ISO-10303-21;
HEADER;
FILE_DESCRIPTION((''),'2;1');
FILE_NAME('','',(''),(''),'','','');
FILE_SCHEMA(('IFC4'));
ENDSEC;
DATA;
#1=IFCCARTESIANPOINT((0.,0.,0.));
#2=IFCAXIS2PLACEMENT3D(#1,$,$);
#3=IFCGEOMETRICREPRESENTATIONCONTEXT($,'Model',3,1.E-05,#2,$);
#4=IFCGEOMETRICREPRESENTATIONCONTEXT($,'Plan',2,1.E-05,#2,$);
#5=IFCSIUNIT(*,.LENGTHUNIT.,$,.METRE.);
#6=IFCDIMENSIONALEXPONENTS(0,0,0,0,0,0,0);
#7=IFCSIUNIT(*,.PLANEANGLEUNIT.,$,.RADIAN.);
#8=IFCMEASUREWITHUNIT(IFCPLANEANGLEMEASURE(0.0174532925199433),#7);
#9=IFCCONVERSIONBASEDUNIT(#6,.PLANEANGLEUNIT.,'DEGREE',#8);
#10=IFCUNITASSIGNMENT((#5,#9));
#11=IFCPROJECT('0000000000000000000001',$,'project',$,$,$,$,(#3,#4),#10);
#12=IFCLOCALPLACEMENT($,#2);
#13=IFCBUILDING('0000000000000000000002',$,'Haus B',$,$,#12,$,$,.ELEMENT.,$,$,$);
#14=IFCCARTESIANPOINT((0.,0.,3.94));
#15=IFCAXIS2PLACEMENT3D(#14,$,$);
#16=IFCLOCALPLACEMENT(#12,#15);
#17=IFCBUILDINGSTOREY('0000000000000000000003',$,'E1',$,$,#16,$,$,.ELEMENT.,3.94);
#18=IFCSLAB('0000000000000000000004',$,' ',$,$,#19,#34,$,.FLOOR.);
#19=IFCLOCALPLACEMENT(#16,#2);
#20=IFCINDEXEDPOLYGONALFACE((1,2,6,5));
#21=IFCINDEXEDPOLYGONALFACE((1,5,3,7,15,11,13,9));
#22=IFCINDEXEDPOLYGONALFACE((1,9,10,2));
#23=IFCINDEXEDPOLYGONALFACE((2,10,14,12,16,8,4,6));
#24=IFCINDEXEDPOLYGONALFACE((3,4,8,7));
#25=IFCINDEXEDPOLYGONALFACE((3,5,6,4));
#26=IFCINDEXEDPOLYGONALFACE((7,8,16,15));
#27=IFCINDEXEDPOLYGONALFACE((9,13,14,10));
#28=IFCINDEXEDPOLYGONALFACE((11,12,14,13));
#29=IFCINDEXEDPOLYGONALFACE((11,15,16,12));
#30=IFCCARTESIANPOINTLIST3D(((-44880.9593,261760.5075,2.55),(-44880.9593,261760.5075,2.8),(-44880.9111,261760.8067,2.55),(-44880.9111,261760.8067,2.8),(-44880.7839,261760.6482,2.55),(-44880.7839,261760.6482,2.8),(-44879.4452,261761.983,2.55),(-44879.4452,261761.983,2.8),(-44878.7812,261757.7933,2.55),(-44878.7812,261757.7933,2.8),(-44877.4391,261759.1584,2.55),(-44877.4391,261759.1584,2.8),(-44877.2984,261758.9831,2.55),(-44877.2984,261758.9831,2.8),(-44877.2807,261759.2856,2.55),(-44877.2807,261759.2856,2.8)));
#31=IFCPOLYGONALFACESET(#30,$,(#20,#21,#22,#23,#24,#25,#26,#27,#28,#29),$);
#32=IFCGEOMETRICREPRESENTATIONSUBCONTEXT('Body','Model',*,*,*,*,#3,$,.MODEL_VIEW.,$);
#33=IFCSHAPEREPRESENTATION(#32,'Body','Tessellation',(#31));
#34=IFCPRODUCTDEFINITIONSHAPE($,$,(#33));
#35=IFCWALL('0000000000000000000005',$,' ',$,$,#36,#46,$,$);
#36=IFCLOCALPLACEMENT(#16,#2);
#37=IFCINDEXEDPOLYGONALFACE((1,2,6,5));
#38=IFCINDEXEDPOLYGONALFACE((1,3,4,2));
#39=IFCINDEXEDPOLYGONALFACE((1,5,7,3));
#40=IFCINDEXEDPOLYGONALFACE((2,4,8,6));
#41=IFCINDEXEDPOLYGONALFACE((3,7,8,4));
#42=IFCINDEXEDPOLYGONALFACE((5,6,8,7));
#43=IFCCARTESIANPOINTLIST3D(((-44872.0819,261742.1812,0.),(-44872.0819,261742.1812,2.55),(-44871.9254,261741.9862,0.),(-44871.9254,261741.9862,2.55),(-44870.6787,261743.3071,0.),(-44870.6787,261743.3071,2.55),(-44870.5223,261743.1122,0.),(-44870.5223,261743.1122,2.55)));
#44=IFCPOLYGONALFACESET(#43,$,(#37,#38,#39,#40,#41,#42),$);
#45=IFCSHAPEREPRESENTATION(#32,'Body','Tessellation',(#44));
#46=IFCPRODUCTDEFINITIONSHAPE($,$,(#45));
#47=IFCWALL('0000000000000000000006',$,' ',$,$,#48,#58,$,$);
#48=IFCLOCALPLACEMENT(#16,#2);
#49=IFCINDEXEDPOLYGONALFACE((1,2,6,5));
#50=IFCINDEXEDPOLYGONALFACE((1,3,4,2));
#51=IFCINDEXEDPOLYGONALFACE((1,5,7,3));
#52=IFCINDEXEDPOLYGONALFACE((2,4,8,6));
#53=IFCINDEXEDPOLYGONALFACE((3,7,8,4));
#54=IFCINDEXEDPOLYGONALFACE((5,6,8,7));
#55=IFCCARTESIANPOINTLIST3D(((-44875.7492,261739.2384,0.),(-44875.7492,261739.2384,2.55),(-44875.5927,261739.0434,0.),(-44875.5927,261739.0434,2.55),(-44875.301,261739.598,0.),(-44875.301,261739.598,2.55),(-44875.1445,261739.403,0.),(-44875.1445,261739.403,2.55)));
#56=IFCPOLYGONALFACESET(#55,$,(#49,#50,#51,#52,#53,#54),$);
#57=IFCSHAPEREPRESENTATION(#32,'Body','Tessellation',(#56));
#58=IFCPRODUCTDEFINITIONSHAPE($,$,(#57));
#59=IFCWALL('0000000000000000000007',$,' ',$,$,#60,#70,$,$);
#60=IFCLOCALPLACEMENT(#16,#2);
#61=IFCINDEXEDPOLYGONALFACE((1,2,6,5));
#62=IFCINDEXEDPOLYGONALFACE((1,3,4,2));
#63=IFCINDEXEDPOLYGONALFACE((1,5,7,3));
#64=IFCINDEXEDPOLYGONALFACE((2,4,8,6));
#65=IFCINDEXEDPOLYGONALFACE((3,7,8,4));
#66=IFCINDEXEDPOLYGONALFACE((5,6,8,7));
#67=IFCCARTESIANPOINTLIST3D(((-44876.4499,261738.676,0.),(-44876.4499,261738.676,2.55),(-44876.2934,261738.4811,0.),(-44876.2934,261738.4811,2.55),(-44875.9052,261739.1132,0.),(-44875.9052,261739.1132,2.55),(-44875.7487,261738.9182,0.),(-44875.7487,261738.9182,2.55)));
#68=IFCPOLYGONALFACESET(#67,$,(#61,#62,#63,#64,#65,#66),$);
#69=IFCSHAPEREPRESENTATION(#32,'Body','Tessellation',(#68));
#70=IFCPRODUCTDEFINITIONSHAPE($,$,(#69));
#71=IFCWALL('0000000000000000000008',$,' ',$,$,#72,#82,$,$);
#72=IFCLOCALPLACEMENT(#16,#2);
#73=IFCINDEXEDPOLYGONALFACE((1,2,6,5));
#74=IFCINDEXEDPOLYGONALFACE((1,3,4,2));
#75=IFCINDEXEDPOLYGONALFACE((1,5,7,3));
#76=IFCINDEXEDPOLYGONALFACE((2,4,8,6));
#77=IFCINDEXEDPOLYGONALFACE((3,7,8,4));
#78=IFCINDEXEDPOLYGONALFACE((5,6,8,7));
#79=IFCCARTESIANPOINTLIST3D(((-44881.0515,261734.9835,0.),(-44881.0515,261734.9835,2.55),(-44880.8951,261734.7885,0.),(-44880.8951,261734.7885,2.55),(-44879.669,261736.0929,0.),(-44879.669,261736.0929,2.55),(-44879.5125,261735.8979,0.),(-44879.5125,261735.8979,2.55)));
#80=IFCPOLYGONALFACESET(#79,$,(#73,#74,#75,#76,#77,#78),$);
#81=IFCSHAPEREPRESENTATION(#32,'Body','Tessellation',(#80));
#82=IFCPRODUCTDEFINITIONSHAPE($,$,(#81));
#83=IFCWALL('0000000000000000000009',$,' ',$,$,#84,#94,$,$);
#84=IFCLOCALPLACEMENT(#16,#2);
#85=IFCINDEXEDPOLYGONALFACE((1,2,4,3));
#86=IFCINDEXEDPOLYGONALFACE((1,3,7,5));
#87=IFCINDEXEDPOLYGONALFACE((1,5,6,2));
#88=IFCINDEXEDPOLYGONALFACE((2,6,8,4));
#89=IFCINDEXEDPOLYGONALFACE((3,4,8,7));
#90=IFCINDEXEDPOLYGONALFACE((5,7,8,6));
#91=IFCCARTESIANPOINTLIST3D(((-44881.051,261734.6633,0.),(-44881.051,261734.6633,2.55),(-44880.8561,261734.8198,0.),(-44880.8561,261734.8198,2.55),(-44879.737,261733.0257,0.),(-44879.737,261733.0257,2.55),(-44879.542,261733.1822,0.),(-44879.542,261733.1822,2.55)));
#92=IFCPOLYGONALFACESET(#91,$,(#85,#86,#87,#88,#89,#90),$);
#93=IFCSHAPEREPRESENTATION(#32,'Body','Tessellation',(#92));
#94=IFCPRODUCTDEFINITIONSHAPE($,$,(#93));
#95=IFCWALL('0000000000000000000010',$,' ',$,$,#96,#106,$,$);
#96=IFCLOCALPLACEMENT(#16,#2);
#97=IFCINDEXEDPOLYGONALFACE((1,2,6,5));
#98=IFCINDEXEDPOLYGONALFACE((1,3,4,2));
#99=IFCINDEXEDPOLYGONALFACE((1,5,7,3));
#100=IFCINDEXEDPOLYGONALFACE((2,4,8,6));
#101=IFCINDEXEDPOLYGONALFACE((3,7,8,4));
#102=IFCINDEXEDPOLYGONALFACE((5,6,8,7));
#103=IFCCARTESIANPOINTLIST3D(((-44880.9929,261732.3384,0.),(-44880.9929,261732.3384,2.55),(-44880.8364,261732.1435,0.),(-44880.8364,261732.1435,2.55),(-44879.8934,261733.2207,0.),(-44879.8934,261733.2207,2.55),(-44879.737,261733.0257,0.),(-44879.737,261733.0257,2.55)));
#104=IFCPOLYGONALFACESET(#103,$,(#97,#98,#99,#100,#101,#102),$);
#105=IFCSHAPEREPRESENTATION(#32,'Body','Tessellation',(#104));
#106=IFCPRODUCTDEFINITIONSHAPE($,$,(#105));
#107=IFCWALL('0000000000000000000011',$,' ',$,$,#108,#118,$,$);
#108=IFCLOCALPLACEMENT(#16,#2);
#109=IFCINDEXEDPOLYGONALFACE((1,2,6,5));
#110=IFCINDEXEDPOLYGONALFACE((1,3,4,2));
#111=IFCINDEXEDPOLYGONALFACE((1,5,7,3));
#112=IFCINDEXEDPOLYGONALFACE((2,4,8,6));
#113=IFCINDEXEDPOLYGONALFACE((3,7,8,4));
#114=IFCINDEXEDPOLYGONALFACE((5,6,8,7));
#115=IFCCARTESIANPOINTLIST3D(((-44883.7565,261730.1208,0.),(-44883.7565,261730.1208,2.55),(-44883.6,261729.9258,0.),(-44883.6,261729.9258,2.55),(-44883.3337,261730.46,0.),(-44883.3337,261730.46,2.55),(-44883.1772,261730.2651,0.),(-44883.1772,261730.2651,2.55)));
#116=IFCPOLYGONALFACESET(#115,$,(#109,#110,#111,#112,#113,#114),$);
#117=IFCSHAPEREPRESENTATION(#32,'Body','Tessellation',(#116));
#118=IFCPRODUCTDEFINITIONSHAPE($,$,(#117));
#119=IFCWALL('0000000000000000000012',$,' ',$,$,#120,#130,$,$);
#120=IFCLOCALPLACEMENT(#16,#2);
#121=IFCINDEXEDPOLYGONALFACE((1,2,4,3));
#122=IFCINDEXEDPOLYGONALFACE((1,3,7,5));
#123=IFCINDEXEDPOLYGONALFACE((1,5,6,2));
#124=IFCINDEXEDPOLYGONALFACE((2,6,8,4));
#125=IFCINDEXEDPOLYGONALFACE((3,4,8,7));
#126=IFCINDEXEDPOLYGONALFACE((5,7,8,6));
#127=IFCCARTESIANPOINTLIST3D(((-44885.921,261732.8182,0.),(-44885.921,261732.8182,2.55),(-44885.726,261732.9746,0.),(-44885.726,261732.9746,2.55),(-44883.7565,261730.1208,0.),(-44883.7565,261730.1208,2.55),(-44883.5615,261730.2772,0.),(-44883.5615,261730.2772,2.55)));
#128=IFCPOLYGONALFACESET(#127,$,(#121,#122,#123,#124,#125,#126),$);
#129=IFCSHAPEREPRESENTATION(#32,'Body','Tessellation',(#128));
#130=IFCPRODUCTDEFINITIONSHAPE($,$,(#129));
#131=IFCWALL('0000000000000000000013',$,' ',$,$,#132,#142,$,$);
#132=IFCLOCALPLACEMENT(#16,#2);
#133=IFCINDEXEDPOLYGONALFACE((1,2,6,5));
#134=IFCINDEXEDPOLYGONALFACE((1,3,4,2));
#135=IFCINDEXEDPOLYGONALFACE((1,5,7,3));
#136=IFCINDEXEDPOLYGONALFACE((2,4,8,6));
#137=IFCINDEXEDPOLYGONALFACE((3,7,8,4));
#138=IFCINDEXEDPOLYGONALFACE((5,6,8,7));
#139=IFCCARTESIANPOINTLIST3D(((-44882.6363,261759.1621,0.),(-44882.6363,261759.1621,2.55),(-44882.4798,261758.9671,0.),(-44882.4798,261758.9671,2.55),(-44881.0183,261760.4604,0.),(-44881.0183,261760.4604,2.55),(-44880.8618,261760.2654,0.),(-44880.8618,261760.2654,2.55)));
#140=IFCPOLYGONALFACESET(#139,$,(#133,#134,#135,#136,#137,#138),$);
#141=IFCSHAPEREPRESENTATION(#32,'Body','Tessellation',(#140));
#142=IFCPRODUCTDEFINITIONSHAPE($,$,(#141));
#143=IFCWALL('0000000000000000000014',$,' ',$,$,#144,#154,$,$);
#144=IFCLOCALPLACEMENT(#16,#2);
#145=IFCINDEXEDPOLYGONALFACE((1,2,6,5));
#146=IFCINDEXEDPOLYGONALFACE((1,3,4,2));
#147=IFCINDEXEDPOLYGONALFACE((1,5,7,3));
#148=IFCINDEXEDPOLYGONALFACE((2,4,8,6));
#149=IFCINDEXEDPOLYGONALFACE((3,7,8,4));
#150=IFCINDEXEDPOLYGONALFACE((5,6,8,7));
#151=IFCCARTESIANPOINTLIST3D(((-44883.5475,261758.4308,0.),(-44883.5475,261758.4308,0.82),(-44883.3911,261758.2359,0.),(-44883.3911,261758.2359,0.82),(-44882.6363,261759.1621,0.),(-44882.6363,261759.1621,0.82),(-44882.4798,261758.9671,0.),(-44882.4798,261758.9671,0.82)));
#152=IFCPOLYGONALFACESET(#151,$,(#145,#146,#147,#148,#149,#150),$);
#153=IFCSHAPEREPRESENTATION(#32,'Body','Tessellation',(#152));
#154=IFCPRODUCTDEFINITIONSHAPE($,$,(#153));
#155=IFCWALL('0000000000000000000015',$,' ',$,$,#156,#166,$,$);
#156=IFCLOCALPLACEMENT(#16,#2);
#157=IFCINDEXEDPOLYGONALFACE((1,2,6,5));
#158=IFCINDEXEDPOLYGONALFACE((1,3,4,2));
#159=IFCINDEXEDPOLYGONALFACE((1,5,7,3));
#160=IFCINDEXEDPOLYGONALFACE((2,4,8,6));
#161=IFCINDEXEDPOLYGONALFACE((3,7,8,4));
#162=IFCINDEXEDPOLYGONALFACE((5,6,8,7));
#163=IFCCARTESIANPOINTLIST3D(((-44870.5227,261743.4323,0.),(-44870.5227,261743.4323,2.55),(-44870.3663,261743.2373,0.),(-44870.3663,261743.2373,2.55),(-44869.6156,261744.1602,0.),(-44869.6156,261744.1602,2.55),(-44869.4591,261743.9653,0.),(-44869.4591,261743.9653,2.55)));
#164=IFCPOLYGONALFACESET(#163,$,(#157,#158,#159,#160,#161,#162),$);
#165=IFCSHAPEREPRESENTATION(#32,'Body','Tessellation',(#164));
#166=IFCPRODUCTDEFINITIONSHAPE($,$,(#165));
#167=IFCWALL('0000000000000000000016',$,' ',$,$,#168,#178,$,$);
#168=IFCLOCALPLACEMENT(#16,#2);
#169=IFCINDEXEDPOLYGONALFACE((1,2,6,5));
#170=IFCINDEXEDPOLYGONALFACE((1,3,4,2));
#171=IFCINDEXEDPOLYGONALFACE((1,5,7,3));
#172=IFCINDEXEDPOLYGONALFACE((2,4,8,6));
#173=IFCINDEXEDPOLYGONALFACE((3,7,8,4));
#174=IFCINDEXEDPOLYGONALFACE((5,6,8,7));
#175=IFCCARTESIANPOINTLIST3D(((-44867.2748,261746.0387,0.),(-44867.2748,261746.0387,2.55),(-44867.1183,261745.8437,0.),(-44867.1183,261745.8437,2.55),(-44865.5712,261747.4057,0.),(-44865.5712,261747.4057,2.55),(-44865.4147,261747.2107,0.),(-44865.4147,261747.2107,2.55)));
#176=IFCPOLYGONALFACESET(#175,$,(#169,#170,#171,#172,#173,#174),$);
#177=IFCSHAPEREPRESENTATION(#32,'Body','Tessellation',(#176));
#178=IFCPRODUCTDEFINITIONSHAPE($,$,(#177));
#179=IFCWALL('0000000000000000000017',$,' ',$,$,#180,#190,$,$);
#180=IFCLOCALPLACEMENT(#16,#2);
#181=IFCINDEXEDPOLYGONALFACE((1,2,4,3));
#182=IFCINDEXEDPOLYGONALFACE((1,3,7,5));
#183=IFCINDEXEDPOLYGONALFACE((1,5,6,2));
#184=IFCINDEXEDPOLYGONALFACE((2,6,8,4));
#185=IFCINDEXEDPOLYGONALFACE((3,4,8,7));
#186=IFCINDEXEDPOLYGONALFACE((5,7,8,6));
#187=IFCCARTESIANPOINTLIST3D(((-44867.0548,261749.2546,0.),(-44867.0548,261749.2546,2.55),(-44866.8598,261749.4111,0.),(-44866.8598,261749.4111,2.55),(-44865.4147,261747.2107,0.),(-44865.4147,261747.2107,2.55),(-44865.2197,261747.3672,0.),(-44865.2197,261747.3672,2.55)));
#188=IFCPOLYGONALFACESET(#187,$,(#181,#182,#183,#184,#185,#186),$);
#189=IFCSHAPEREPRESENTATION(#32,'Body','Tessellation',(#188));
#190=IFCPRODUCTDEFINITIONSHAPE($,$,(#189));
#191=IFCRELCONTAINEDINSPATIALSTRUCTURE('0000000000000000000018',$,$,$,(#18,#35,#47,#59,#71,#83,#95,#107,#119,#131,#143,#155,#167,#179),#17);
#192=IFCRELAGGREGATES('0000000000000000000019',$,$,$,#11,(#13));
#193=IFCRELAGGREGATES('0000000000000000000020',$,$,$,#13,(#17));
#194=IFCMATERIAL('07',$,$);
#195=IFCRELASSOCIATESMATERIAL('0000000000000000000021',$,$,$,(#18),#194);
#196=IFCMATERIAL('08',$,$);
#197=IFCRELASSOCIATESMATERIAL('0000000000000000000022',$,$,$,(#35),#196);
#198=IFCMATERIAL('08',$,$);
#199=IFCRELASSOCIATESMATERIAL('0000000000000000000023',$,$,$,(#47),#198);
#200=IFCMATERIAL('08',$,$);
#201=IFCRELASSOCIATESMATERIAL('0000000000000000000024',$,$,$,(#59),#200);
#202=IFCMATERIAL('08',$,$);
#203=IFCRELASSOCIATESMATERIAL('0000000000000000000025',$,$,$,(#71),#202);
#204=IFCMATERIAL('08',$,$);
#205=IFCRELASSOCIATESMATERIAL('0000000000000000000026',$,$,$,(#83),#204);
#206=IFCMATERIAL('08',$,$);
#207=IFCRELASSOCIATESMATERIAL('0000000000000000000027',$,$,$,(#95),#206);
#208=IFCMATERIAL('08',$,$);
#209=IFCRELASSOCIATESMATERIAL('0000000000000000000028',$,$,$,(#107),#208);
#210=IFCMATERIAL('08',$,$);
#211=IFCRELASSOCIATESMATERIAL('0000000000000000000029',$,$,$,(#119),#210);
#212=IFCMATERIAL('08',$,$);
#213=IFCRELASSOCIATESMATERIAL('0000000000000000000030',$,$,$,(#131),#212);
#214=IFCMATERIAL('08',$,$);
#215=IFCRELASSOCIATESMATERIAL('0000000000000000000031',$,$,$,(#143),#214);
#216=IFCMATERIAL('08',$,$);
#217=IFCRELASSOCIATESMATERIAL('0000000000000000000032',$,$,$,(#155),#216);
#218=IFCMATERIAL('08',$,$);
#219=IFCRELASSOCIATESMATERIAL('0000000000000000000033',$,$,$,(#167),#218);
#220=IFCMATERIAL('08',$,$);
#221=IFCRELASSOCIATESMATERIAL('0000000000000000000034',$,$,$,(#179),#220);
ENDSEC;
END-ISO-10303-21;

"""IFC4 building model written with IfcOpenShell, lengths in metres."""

from ifc_helpers import new_model, entity, si_unit, converted_unit, frame, frame_2d, origin, origin_with_axes, place, context, subcontext, project, spatial, polyline, rectangle, outline, extrude, material, element, save


model = new_model("IFC4")

# Units and contexts
model_context = context("Model", 3, precision=1e-05, world=origin())
plan_context = context("Plan", 2, precision=1e-05, world=origin())
body_context = subcontext(model_context, "Body", "Model", "MODEL_VIEW")
ifc_project = project(units=[si_unit("LENGTHUNIT", "METRE"), converted_unit("PLANEANGLEUNIT", "DEGREE", entity("IfcPlaneAngleMeasure", 0.0174532925199433), si_unit("PLANEANGLEUNIT", "RADIAN"), dimensions=[0, 0, 0, 0, 0, 0, 0])], contexts=[model_context, plan_context])

# Building, storey
building_placement = place(None, origin())
building = spatial("IfcBuilding", under=ifc_project, at=building_placement, Name="Haus B", CompositionType="ELEMENT")
storey_placement = place(building_placement, frame((0.0, 0.0, 3.94)))
storey = spatial("IfcBuildingStorey", under=building, at=storey_placement, Name="E1", CompositionType="ELEMENT", Elevation=3.94)

# Slab
ifc_material_1 = material(Name="07")
slab_placement = place(storey_placement, frame((-44880.9593, 261757.7933, 2.55)))
element("IfcSlab", 1, at=slab_placement, inside=storey, material=ifc_material_1, Name=" ", PredefinedType="FLOOR", context=body_context, shape_type="SweptSolid", body=[
    extrude(outline(polyline([(0.0, 2.7142), (2.1781, 0.0), (3.6608, 1.1898), (3.5201, 1.3652), (3.6786, 1.4923), (1.5141, 4.1897), (0.0482, 3.0134), (0.1753, 2.8549), (0.0, 2.7142)])), origin_with_axes(), (0.0, 0.0, 1.0), 0.25),
])

# Walls
ifc_material_2 = material(Name="08")
wall_1_placement = place(storey_placement, frame((-44870.6787, 261743.3071, 0.0), z_axis=(0.0, 0.0, 1.0), x_axis=(-0.779935, -0.625861, 0.0)))
element("IfcWall", 2, at=wall_1_placement, inside=storey, material=ifc_material_2, Name=" ", context=body_context, shape_type="SweptSolid", body=[
    extrude(rectangle(XDim=1.7991, YDim=0.25, at=frame_2d((0.8995, 0.125), x_axis=(1.0, 0.0))), origin_with_axes(), (0.0, 0.0, 1.0), 2.55),
])
ifc_material_3 = material(Name="08")
wall_2_placement = place(storey_placement, frame((-44875.301, 261739.598, 0.0), z_axis=(0.0, 0.0, 1.0), x_axis=(-0.779935, -0.625861, 0.0)))
element("IfcWall", 3, at=wall_2_placement, inside=storey, material=ifc_material_3, Name=" ", context=body_context, shape_type="SweptSolid", body=[
    extrude(rectangle(XDim=0.5747, YDim=0.25, at=frame_2d((0.2873, 0.125), x_axis=(1.0, 0.0))), origin_with_axes(), (0.0, 0.0, 1.0), 2.55),
])
ifc_material_4 = material(Name="08")
wall_3_placement = place(storey_placement, frame((-44875.9052, 261739.1132, 0.0), z_axis=(0.0, 0.0, 1.0), x_axis=(-0.779935, -0.625861, 0.0)))
element("IfcWall", 4, at=wall_3_placement, inside=storey, material=ifc_material_4, Name=" ", context=body_context, shape_type="SweptSolid", body=[
    extrude(rectangle(XDim=0.6985, YDim=0.25, at=frame_2d((0.3492, 0.125), x_axis=(1.0, 0.0))), origin_with_axes(), (0.0, 0.0, 1.0), 2.55),
])
ifc_material_5 = material(Name="08")
wall_4_placement = place(storey_placement, frame((-44879.669, 261736.0929, 0.0), z_axis=(0.0, 0.0, 1.0), x_axis=(-0.779935, -0.625861, 0.0)))
element("IfcWall", 5, at=wall_4_placement, inside=storey, material=ifc_material_5, Name=" ", context=body_context, shape_type="SweptSolid", body=[
    extrude(rectangle(XDim=1.7727, YDim=0.25, at=frame_2d((0.8863, 0.125), x_axis=(1.0, 0.0))), origin_with_axes(), (0.0, 0.0, 1.0), 2.55),
])
ifc_material_6 = material(Name="08")
wall_5_placement = place(storey_placement, frame((-44881.051, 261734.6633, 0.0), z_axis=(0.0, 0.0, 1.0), x_axis=(0.625861, -0.779935, 0.0)))
element("IfcWall", 6, at=wall_5_placement, inside=storey, material=ifc_material_6, Name=" ", context=body_context, shape_type="SweptSolid", body=[
    extrude(rectangle(XDim=2.0997, YDim=0.25, at=frame_2d((1.0498, 0.125), x_axis=(1.0, 0.0))), origin_with_axes(), (0.0, 0.0, 1.0), 2.55),
])
ifc_material_7 = material(Name="08")
wall_6_placement = place(storey_placement, frame((-44879.8934, 261733.2207, 0.0), z_axis=(0.0, 0.0, 1.0), x_axis=(-0.779935, -0.625861, 0.0)))
element("IfcWall", 7, at=wall_6_placement, inside=storey, material=ifc_material_7, Name=" ", context=body_context, shape_type="SweptSolid", body=[
    extrude(rectangle(XDim=1.4096, YDim=0.25, at=frame_2d((0.7048, 0.125), x_axis=(1.0, 0.0))), origin_with_axes(), (0.0, 0.0, 1.0), 2.55),
])
ifc_material_8 = material(Name="08")
wall_7_placement = place(storey_placement, frame((-44883.3337, 261730.46, 0.0), z_axis=(0.0, 0.0, 1.0), x_axis=(-0.779935, -0.625861, 0.0)))
element("IfcWall", 8, at=wall_7_placement, inside=storey, material=ifc_material_8, Name=" ", context=body_context, shape_type="SweptSolid", body=[
    extrude(rectangle(XDim=0.5421, YDim=0.25, at=frame_2d((0.271, 0.125), x_axis=(1.0, 0.0))), origin_with_axes(), (0.0, 0.0, 1.0), 2.55),
])
ifc_material_9 = material(Name="08")
wall_8_placement = place(storey_placement, frame((-44883.5615, 261730.2772, 0.0), z_axis=(0.0, 0.0, 1.0), x_axis=(-0.625861, 0.779935, 0.0)))
element("IfcWall", 9, at=wall_8_placement, inside=storey, material=ifc_material_9, Name=" ", context=body_context, shape_type="SweptSolid", body=[
    extrude(rectangle(XDim=3.4585, YDim=0.25, at=frame_2d((1.7292, 0.125), x_axis=(1.0, 0.0))), origin_with_axes(), (0.0, 0.0, 1.0), 2.55),
])
ifc_material_10 = material(Name="08")
wall_9_placement = place(storey_placement, frame((-44882.4798, 261758.9671, 0.0), z_axis=(0.0, 0.0, 1.0), x_axis=(0.779935, 0.625861, 0.0)))
element("IfcWall", 10, at=wall_9_placement, inside=storey, material=ifc_material_10, Name=" ", context=body_context, shape_type="SweptSolid", body=[
    extrude(rectangle(XDim=2.0745, YDim=0.25, at=frame_2d((1.0372, 0.125), x_axis=(1.0, 0.0))), origin_with_axes(), (0.0, 0.0, 1.0), 2.55),
])
ifc_material_11 = material(Name="08")
wall_10_placement = place(storey_placement, frame((-44883.3911, 261758.2359, 0.0), z_axis=(0.0, 0.0, 1.0), x_axis=(0.779935, 0.625861, 0.0)))
element("IfcWall", 11, at=wall_10_placement, inside=storey, material=ifc_material_11, Name=" ", context=body_context, shape_type="SweptSolid", body=[
    extrude(rectangle(XDim=1.1684, YDim=0.25, at=frame_2d((0.5842, 0.125), x_axis=(1.0, 0.0))), origin_with_axes(), (0.0, 0.0, 1.0), 0.82),
])
ifc_material_12 = material(Name="08")
wall_11_placement = place(storey_placement, frame((-44869.6156, 261744.1602, 0.0), z_axis=(0.0, 0.0, 1.0), x_axis=(-0.779935, -0.625861, 0.0)))
element("IfcWall", 12, at=wall_11_placement, inside=storey, material=ifc_material_12, Name=" ", context=body_context, shape_type="SweptSolid", body=[
    extrude(rectangle(XDim=1.1631, YDim=0.25, at=frame_2d((0.5815, 0.125), x_axis=(1.0, 0.0))), origin_with_axes(), (0.0, 0.0, 1.0), 2.55),
])
ifc_material_13 = material(Name="08")
wall_12_placement = place(storey_placement, frame((-44865.5712, 261747.4057, 0.0), z_axis=(0.0, 0.0, 1.0), x_axis=(-0.779935, -0.625861, 0.0)))
element("IfcWall", 13, at=wall_12_placement, inside=storey, material=ifc_material_13, Name=" ", context=body_context, shape_type="SweptSolid", body=[
    extrude(rectangle(XDim=2.1843, YDim=0.25, at=frame_2d((1.0922, 0.125), x_axis=(1.0, 0.0))), origin_with_axes(), (0.0, 0.0, 1.0), 2.55),
])
ifc_material_14 = material(Name="08")
wall_13_placement = place(storey_placement, frame((-44867.0548, 261749.2546, 0.0), z_axis=(0.0, 0.0, 1.0), x_axis=(0.625861, -0.779935, 0.0)))
element("IfcWall", 14, at=wall_13_placement, inside=storey, material=ifc_material_14, Name=" ", context=body_context, shape_type="SweptSolid", body=[
    extrude(rectangle(XDim=2.6206, YDim=0.25, at=frame_2d((1.3103, 0.125), x_axis=(1.0, 0.0))), origin_with_axes(), (0.0, 0.0, 1.0), 2.55),
])

save(model, "model.ifc")
